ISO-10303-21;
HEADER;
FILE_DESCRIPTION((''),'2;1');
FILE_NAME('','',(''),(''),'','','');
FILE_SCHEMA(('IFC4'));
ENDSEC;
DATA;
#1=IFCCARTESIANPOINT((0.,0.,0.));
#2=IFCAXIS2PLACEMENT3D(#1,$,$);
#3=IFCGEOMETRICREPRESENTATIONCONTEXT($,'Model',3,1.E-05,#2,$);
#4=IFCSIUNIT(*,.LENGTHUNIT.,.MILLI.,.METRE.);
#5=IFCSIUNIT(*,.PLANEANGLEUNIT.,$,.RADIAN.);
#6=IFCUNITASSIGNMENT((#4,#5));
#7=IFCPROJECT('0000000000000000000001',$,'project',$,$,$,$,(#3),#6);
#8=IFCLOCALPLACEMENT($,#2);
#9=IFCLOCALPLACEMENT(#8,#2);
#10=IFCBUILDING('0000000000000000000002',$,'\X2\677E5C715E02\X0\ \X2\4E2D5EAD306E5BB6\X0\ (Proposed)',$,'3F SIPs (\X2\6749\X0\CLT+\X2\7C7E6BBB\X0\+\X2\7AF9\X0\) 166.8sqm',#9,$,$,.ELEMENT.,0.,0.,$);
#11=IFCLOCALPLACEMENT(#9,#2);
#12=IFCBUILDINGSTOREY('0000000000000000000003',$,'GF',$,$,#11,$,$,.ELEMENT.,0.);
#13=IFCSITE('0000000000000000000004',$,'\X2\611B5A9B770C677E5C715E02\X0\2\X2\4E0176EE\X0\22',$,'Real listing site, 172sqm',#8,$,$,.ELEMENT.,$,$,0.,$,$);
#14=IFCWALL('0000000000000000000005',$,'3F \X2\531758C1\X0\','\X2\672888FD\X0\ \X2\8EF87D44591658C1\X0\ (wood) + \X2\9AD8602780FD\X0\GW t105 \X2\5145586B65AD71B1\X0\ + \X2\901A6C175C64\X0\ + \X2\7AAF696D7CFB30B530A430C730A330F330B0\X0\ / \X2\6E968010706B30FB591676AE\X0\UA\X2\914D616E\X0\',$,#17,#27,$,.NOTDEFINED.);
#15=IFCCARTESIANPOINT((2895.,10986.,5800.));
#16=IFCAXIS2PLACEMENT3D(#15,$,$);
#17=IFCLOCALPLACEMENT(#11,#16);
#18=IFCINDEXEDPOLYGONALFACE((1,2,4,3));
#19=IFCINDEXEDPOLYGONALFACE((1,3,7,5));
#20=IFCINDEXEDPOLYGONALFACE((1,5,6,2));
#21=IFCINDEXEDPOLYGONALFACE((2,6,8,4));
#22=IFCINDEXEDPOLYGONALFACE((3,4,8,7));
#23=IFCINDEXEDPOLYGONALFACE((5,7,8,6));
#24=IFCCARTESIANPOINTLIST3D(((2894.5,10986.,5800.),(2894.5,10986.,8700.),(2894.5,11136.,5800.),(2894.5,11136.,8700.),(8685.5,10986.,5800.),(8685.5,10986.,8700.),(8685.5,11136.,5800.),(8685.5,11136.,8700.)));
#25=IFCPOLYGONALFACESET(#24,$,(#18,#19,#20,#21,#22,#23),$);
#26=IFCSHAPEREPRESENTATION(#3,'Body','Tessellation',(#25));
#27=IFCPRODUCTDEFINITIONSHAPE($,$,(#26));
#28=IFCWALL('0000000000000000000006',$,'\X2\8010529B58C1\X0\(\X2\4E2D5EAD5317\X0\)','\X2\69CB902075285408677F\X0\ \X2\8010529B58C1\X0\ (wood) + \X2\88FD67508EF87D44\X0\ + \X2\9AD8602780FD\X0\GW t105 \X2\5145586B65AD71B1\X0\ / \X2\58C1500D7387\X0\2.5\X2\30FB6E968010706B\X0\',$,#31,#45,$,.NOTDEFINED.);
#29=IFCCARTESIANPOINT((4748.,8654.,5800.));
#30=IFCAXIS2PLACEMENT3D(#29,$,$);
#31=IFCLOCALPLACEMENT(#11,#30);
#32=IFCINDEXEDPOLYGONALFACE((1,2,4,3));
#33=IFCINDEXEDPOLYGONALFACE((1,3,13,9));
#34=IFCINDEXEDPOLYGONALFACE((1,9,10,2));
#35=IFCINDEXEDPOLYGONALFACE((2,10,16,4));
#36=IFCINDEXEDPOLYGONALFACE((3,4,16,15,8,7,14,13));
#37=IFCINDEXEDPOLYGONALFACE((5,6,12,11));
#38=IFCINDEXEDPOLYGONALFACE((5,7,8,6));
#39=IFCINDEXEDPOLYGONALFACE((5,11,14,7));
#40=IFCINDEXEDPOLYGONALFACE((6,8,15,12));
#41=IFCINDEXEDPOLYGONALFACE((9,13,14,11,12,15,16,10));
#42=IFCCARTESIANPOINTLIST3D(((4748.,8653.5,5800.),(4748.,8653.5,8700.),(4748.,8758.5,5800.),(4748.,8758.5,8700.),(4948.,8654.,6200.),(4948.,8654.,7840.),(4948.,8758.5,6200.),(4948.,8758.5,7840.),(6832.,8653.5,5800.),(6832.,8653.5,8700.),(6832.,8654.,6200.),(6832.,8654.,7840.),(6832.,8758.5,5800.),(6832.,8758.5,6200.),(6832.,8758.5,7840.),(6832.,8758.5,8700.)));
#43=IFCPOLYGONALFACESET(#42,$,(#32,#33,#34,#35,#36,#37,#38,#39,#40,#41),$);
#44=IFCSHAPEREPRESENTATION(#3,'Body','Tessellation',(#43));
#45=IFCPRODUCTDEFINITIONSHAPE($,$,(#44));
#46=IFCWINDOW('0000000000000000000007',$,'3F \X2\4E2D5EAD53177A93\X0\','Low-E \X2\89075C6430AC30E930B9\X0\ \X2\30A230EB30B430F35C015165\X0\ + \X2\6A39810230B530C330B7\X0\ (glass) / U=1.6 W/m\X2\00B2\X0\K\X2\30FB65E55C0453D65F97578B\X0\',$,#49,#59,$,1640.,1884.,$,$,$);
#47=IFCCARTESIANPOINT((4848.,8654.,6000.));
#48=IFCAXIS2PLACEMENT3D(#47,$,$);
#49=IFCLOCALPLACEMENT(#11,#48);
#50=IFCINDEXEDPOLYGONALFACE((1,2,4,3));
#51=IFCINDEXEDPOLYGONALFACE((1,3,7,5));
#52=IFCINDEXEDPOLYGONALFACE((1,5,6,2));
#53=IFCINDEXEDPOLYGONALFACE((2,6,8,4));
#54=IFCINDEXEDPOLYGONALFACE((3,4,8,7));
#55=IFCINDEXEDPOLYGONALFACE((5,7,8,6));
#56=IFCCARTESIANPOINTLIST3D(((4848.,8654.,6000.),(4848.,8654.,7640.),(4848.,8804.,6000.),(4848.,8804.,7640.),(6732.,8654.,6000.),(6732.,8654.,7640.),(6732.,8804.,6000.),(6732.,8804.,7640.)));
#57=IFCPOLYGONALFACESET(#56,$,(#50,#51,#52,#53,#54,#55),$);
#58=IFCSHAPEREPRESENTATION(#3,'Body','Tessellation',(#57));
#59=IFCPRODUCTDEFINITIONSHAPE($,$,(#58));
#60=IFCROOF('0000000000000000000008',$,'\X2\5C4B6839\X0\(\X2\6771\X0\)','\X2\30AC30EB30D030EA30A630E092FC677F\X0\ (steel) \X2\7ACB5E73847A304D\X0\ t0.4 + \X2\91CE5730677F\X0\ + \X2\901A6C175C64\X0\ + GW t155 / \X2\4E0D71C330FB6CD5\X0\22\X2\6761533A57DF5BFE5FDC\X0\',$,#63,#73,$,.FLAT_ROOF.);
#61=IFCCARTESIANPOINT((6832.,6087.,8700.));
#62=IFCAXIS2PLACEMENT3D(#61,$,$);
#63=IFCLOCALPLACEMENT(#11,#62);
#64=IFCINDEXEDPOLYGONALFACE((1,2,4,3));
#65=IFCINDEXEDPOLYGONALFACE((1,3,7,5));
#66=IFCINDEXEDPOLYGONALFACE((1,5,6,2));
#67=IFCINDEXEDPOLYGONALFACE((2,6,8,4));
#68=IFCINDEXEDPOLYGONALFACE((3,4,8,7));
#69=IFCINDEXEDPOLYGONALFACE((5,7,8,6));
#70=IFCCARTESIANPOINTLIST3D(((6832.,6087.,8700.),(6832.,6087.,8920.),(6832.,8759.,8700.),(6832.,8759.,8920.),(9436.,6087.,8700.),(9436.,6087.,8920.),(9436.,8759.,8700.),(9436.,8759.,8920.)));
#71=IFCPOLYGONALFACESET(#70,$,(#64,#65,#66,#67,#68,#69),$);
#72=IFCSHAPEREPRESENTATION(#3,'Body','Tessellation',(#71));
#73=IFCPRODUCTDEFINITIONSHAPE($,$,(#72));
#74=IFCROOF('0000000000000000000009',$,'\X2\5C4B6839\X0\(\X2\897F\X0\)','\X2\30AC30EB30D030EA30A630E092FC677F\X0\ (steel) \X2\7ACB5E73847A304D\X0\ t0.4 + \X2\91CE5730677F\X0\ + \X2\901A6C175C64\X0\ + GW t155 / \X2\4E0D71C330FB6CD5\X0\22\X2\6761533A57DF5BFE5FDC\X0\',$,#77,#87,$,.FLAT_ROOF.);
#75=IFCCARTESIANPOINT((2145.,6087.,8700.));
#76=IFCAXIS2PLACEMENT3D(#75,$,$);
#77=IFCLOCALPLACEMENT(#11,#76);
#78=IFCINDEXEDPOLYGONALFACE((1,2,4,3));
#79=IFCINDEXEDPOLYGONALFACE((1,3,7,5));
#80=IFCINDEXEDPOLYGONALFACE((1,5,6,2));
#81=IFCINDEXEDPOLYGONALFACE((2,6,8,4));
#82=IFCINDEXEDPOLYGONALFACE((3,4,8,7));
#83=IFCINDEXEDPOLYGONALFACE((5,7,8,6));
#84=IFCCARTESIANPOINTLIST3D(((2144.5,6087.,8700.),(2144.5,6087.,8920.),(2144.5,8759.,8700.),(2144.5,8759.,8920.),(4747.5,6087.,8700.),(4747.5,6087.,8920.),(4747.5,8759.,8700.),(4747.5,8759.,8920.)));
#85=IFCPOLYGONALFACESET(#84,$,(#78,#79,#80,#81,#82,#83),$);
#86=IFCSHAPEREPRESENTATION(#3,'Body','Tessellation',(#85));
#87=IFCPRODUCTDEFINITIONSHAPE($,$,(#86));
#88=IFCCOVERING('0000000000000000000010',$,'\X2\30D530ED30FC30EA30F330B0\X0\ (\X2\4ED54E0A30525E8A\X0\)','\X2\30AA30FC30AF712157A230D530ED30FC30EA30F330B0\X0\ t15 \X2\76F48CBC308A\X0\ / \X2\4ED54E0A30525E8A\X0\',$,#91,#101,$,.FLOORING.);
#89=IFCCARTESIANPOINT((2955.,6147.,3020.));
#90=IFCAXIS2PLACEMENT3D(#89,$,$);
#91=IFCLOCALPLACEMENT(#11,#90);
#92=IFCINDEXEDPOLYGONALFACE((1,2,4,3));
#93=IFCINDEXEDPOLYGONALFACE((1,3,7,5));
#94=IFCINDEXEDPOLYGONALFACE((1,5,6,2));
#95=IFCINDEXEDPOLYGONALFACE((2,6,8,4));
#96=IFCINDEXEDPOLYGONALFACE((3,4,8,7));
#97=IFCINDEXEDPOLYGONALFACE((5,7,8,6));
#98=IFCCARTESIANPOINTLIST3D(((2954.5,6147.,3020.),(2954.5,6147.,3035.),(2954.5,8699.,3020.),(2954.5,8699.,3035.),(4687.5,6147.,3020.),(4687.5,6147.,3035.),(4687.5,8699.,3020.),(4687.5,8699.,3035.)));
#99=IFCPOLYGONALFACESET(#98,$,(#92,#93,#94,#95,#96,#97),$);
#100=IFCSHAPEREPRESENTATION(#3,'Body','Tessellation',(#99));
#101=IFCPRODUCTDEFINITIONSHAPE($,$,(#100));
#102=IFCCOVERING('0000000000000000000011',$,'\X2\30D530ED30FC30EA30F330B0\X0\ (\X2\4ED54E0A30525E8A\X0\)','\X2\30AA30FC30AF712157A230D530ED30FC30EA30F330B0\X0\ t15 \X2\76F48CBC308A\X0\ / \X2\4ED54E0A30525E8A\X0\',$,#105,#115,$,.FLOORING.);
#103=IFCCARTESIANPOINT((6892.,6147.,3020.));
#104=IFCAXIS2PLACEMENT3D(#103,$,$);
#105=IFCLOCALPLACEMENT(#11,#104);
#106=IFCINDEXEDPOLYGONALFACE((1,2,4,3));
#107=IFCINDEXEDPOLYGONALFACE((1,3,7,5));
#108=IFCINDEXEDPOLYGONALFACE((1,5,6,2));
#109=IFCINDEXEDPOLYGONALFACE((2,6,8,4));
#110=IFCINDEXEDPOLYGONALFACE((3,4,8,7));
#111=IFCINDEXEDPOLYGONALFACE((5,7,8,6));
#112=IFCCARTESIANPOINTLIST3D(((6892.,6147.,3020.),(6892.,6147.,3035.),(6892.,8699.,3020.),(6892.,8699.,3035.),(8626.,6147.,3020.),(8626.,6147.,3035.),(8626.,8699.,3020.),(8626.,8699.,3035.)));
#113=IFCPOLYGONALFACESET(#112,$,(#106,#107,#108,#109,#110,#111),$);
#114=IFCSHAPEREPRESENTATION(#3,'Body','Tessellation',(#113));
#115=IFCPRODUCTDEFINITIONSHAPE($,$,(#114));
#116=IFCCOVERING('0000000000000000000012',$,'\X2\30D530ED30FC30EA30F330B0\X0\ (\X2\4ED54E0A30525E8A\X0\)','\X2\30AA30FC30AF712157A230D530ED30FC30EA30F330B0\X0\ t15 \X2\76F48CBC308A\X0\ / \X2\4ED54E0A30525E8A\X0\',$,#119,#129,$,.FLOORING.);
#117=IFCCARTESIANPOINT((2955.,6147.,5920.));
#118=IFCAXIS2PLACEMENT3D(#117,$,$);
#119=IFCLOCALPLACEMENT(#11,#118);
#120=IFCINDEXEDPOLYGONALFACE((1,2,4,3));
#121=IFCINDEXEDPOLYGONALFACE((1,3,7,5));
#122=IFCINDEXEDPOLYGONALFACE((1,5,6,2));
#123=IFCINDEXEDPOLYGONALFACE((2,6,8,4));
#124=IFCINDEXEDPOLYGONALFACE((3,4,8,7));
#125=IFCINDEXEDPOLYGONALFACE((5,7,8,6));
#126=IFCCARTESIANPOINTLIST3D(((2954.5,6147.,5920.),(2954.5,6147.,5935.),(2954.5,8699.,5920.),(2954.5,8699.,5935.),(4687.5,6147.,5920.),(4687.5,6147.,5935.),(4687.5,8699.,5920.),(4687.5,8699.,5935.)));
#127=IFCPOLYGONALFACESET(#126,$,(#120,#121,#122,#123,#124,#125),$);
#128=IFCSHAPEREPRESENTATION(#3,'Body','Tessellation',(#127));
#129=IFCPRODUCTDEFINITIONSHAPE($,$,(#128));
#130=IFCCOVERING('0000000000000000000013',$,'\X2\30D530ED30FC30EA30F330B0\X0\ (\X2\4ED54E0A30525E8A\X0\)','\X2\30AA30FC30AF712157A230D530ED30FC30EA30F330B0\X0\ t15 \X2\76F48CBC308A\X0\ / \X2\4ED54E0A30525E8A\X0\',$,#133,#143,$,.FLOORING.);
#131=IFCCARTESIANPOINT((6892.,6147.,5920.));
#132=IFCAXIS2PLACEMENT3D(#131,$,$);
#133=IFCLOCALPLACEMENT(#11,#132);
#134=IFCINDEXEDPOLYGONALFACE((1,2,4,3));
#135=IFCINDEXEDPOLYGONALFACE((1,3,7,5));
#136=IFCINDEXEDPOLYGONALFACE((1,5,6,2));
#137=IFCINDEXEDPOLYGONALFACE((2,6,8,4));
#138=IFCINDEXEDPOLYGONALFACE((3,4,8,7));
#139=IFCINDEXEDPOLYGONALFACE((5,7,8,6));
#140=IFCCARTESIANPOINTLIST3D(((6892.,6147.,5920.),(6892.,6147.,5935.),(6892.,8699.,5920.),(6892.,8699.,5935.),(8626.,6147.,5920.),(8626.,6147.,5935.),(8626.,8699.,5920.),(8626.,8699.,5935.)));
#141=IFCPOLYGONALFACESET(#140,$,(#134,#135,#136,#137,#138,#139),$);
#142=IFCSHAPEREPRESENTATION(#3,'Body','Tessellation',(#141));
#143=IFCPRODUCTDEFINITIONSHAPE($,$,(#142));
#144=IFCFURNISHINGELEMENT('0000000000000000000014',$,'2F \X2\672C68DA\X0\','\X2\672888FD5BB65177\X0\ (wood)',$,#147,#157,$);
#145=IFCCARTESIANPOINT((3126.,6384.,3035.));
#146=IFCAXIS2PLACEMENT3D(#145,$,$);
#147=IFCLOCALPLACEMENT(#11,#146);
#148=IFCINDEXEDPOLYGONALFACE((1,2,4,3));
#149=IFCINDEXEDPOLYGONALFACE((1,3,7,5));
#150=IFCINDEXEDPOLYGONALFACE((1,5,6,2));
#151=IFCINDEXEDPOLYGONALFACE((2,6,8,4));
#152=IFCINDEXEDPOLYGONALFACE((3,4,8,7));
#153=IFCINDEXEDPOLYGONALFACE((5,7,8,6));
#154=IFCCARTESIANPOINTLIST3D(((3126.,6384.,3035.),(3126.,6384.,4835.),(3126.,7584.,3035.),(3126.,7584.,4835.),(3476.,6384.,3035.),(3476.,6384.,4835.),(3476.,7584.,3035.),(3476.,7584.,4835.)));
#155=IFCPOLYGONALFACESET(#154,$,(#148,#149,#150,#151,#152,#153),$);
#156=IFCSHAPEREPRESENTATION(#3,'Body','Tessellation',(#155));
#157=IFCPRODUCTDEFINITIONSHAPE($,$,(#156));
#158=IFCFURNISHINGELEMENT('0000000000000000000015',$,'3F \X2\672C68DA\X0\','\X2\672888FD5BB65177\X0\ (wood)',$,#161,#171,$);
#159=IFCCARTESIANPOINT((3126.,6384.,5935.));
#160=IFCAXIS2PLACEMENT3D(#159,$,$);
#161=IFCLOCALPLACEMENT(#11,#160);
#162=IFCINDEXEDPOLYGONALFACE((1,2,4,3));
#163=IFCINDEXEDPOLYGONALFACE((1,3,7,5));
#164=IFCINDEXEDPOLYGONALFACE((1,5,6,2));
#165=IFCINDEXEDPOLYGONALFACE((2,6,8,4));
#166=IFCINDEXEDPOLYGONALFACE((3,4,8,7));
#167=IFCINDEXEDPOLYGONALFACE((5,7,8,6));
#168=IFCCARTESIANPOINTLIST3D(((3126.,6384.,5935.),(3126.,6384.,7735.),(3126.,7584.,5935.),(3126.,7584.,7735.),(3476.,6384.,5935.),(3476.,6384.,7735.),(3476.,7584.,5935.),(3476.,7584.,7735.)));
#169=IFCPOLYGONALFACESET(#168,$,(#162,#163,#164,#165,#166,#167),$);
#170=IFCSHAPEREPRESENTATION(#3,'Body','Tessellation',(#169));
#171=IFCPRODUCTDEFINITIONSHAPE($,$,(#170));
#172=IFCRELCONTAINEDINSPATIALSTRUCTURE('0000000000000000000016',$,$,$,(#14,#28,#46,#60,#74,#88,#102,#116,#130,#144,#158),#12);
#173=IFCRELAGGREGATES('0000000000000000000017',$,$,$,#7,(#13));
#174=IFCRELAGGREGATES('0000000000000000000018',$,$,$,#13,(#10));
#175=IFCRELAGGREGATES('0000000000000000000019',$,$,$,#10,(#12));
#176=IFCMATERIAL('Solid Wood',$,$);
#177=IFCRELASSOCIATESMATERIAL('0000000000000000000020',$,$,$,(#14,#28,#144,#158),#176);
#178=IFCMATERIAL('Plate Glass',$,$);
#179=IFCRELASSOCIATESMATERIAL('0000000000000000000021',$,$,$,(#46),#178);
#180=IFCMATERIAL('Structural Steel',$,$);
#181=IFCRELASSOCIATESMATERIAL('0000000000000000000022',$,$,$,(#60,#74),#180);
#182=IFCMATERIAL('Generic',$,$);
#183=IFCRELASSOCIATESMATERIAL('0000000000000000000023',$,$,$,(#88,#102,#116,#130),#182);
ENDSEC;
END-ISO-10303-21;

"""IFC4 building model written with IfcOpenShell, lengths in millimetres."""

from ifc_helpers import new_model, si_unit, frame, frame_2d, origin, place, context, project, spatial, rectangle, extrude, material, element, fill, save


model = new_model("IFC4")

# Units and contexts
model_context = context("Model", 3, precision=1e-05, world=origin())
ifc_project = project(units=[si_unit("LENGTHUNIT", "METRE", prefix="MILLI"), si_unit("PLANEANGLEUNIT", "RADIAN")], contexts=[model_context])

# Site, building, storey
site_placement = place(None, origin())
site = spatial("IfcSite", under=ifc_project, at=site_placement, Name="愛媛県松山市2丁目22", ObjectType="Real listing site, 172sqm", CompositionType="ELEMENT", RefElevation=0.0)
building_placement = place(site_placement, origin())
building = spatial("IfcBuilding", under=site, at=building_placement, Name="松山市 中庭の家 (Proposed)", ObjectType="3F SIPs (杉CLT+籾殻+竹) 166.8sqm", CompositionType="ELEMENT", ElevationOfRefHeight=0.0, ElevationOfTerrain=0.0)
storey_placement = place(building_placement, origin())
storey = spatial("IfcBuildingStorey", under=building, at=storey_placement, Name="GF", CompositionType="ELEMENT", Elevation=0.0)

# Shared definitions
ifc_material_1 = material(Name="Solid Wood")

# Wall
wall_1_placement = place(storey_placement, frame((2895.0, 10986.0, 5800.0)))
element("IfcWall", 1, at=wall_1_placement, inside=storey, material=ifc_material_1, Name="3F 北壁", Description="木製 軸組外壁 (wood) + 高性能GW t105 充填断熱 + 通気層 + 窯業系サイディング / 準耐火・外皮UA配慮", PredefinedType="NOTDEFINED", context=model_context, shape_type="SweptSolid", body=[
    extrude(rectangle(XDim=5791.0, YDim=150.0, at=frame_2d((2895.0, 75.0))), frame((2895.0, 10986.0, 5800.0)), (0.0, 0.0, 1.0), 2900.0),
])

# Wall, opening, window
wall_2_placement = place(storey_placement, frame((4748.0, 8654.0, 5800.0)))
wall_2 = element("IfcWall", 2, at=wall_2_placement, inside=storey, material=ifc_material_1, Name="耐力壁(中庭北)", Description="構造用合板 耐力壁 (wood) + 製材軸組 + 高性能GW t105 充填断熱 / 壁倍率2.5・準耐火", PredefinedType="NOTDEFINED", context=model_context, shape_type="SweptSolid", body=[
    extrude(rectangle(XDim=2084.0, YDim=105.0, at=frame_2d((1042.0, 52.0))), frame((4748.0, 8654.0, 5800.0)), (0.0, 0.0, 1.0), 2900.0),
])
opening_placement = place(storey_placement, frame((4848.0, 8654.0, 6000.0)))
opening = element("IfcOpeningElement", 3, at=opening_placement, cuts=wall_2, PredefinedType="NOTDEFINED", context=model_context, shape_type="SweptSolid", body=[
    extrude(rectangle(XDim=1884.0, YDim=150.0, at=frame_2d((942.0, 75.0))), frame((4848.0, 8654.0, 6000.0)), (0.0, 0.0, 1.0), 1640.0),
])
ifc_material_2 = material(Name="Plate Glass")
window_1_placement = place(storey_placement, frame((4848.0, 8654.0, 6000.0)))
window_1 = element("IfcWindow", 4, at=window_1_placement, inside=storey, material=ifc_material_2, Name="3F 中庭北窓", Description="Low-E 複層ガラス アルゴン封入 + 樹脂サッシ (glass) / U=1.6 W/m²K・日射取得型", OverallHeight=1640.0, OverallWidth=1884.0, context=model_context, shape_type="SweptSolid", body=[
    extrude(rectangle(XDim=1884.0, YDim=150.0, at=frame_2d((942.0, 75.0))), frame((4848.0, 8654.0, 6000.0)), (0.0, 0.0, 1.0), 1640.0),
])
fill(opening, window_1)

# Shared definitions
ifc_material_3 = material(Name="Generic")

# Roofs
ifc_material_4 = material(Name="Structural Steel")
roof_1_placement = place(storey_placement, frame((6832.0, 6087.0, 8700.0)))
element("IfcRoof", 5, at=roof_1_placement, inside=storey, material=ifc_material_4, Name="屋根(東)", Description="ガルバリウム鋼板 (steel) 立平葺き t0.4 + 野地板 + 通気層 + GW t155 / 不燃・法22条区域対応", PredefinedType="FLAT_ROOF", context=model_context, shape_type="SweptSolid", body=[
    extrude(rectangle(XDim=2604.0, YDim=2672.0, at=frame_2d((1302.0, 1336.0))), frame((6832.0, 6087.0, 8700.0)), (0.0, 0.0, 1.0), 220.0),
])
roof_2_placement = place(storey_placement, frame((2145.0, 6087.0, 8700.0)))
element("IfcRoof", 6, at=roof_2_placement, inside=storey, material=ifc_material_4, Name="屋根(西)", Description="ガルバリウム鋼板 (steel) 立平葺き t0.4 + 野地板 + 通気層 + GW t155 / 不燃・法22条区域対応", PredefinedType="FLAT_ROOF", context=model_context, shape_type="SweptSolid", body=[
    extrude(rectangle(XDim=2603.0, YDim=2672.0, at=frame_2d((1301.0, 1336.0))), frame((2145.0, 6087.0, 8700.0)), (0.0, 0.0, 1.0), 220.0),
])

# Coverings
covering_1_placement = place(storey_placement, frame((2955.0, 6147.0, 3020.0)))
element("IfcCovering", 7, at=covering_1_placement, inside=storey, material=ifc_material_3, Name="フローリング (仕上げ床)", Description="オーク無垢フローリング t15 直貼り / 仕上げ床", PredefinedType="FLOORING", context=model_context, shape_type="SweptSolid", body=[
    extrude(rectangle(XDim=1733.0, YDim=2552.0, at=frame_2d((866.0, 1276.0))), frame((2955.0, 6147.0, 3020.0)), (0.0, 0.0, 1.0), 15.0),
])
covering_2_placement = place(storey_placement, frame((6892.0, 6147.0, 3020.0)))
element("IfcCovering", 8, at=covering_2_placement, inside=storey, material=ifc_material_3, Name="フローリング (仕上げ床)", Description="オーク無垢フローリング t15 直貼り / 仕上げ床", PredefinedType="FLOORING", context=model_context, shape_type="SweptSolid", body=[
    extrude(rectangle(XDim=1734.0, YDim=2552.0, at=frame_2d((867.0, 1276.0))), frame((6892.0, 6147.0, 3020.0)), (0.0, 0.0, 1.0), 15.0),
])
covering_3_placement = place(storey_placement, frame((2955.0, 6147.0, 5920.0)))
element("IfcCovering", 9, at=covering_3_placement, inside=storey, material=ifc_material_3, Name="フローリング (仕上げ床)", Description="オーク無垢フローリング t15 直貼り / 仕上げ床", PredefinedType="FLOORING", context=model_context, shape_type="SweptSolid", body=[
    extrude(rectangle(XDim=1733.0, YDim=2552.0, at=frame_2d((866.0, 1276.0))), frame((2955.0, 6147.0, 5920.0)), (0.0, 0.0, 1.0), 15.0),
])
covering_4_placement = place(storey_placement, frame((6892.0, 6147.0, 5920.0)))
element("IfcCovering", 10, at=covering_4_placement, inside=storey, material=ifc_material_3, Name="フローリング (仕上げ床)", Description="オーク無垢フローリング t15 直貼り / 仕上げ床", PredefinedType="FLOORING", context=model_context, shape_type="SweptSolid", body=[
    extrude(rectangle(XDim=1734.0, YDim=2552.0, at=frame_2d((867.0, 1276.0))), frame((6892.0, 6147.0, 5920.0)), (0.0, 0.0, 1.0), 15.0),
])

# Furnishing elements
furnishing_1_placement = place(storey_placement, frame((3126.0, 6384.0, 3035.0)))
element("IfcFurnishingElement", 11, at=furnishing_1_placement, inside=storey, material=ifc_material_1, Name="2F 本棚", Description="木製家具 (wood)", context=model_context, shape_type="SweptSolid", body=[
    extrude(rectangle(XDim=350.0, YDim=1200.0, at=frame_2d((175.0, 600.0))), frame((3126.0, 6384.0, 3035.0)), (0.0, 0.0, 1.0), 1800.0),
])
furnishing_2_placement = place(storey_placement, frame((3126.0, 6384.0, 5935.0)))
element("IfcFurnishingElement", 12, at=furnishing_2_placement, inside=storey, material=ifc_material_1, Name="3F 本棚", Description="木製家具 (wood)", context=model_context, shape_type="SweptSolid", body=[
    extrude(rectangle(XDim=350.0, YDim=1200.0, at=frame_2d((175.0, 600.0))), frame((3126.0, 6384.0, 5935.0)), (0.0, 0.0, 1.0), 1800.0),
])

save(model, "model.ifc")
